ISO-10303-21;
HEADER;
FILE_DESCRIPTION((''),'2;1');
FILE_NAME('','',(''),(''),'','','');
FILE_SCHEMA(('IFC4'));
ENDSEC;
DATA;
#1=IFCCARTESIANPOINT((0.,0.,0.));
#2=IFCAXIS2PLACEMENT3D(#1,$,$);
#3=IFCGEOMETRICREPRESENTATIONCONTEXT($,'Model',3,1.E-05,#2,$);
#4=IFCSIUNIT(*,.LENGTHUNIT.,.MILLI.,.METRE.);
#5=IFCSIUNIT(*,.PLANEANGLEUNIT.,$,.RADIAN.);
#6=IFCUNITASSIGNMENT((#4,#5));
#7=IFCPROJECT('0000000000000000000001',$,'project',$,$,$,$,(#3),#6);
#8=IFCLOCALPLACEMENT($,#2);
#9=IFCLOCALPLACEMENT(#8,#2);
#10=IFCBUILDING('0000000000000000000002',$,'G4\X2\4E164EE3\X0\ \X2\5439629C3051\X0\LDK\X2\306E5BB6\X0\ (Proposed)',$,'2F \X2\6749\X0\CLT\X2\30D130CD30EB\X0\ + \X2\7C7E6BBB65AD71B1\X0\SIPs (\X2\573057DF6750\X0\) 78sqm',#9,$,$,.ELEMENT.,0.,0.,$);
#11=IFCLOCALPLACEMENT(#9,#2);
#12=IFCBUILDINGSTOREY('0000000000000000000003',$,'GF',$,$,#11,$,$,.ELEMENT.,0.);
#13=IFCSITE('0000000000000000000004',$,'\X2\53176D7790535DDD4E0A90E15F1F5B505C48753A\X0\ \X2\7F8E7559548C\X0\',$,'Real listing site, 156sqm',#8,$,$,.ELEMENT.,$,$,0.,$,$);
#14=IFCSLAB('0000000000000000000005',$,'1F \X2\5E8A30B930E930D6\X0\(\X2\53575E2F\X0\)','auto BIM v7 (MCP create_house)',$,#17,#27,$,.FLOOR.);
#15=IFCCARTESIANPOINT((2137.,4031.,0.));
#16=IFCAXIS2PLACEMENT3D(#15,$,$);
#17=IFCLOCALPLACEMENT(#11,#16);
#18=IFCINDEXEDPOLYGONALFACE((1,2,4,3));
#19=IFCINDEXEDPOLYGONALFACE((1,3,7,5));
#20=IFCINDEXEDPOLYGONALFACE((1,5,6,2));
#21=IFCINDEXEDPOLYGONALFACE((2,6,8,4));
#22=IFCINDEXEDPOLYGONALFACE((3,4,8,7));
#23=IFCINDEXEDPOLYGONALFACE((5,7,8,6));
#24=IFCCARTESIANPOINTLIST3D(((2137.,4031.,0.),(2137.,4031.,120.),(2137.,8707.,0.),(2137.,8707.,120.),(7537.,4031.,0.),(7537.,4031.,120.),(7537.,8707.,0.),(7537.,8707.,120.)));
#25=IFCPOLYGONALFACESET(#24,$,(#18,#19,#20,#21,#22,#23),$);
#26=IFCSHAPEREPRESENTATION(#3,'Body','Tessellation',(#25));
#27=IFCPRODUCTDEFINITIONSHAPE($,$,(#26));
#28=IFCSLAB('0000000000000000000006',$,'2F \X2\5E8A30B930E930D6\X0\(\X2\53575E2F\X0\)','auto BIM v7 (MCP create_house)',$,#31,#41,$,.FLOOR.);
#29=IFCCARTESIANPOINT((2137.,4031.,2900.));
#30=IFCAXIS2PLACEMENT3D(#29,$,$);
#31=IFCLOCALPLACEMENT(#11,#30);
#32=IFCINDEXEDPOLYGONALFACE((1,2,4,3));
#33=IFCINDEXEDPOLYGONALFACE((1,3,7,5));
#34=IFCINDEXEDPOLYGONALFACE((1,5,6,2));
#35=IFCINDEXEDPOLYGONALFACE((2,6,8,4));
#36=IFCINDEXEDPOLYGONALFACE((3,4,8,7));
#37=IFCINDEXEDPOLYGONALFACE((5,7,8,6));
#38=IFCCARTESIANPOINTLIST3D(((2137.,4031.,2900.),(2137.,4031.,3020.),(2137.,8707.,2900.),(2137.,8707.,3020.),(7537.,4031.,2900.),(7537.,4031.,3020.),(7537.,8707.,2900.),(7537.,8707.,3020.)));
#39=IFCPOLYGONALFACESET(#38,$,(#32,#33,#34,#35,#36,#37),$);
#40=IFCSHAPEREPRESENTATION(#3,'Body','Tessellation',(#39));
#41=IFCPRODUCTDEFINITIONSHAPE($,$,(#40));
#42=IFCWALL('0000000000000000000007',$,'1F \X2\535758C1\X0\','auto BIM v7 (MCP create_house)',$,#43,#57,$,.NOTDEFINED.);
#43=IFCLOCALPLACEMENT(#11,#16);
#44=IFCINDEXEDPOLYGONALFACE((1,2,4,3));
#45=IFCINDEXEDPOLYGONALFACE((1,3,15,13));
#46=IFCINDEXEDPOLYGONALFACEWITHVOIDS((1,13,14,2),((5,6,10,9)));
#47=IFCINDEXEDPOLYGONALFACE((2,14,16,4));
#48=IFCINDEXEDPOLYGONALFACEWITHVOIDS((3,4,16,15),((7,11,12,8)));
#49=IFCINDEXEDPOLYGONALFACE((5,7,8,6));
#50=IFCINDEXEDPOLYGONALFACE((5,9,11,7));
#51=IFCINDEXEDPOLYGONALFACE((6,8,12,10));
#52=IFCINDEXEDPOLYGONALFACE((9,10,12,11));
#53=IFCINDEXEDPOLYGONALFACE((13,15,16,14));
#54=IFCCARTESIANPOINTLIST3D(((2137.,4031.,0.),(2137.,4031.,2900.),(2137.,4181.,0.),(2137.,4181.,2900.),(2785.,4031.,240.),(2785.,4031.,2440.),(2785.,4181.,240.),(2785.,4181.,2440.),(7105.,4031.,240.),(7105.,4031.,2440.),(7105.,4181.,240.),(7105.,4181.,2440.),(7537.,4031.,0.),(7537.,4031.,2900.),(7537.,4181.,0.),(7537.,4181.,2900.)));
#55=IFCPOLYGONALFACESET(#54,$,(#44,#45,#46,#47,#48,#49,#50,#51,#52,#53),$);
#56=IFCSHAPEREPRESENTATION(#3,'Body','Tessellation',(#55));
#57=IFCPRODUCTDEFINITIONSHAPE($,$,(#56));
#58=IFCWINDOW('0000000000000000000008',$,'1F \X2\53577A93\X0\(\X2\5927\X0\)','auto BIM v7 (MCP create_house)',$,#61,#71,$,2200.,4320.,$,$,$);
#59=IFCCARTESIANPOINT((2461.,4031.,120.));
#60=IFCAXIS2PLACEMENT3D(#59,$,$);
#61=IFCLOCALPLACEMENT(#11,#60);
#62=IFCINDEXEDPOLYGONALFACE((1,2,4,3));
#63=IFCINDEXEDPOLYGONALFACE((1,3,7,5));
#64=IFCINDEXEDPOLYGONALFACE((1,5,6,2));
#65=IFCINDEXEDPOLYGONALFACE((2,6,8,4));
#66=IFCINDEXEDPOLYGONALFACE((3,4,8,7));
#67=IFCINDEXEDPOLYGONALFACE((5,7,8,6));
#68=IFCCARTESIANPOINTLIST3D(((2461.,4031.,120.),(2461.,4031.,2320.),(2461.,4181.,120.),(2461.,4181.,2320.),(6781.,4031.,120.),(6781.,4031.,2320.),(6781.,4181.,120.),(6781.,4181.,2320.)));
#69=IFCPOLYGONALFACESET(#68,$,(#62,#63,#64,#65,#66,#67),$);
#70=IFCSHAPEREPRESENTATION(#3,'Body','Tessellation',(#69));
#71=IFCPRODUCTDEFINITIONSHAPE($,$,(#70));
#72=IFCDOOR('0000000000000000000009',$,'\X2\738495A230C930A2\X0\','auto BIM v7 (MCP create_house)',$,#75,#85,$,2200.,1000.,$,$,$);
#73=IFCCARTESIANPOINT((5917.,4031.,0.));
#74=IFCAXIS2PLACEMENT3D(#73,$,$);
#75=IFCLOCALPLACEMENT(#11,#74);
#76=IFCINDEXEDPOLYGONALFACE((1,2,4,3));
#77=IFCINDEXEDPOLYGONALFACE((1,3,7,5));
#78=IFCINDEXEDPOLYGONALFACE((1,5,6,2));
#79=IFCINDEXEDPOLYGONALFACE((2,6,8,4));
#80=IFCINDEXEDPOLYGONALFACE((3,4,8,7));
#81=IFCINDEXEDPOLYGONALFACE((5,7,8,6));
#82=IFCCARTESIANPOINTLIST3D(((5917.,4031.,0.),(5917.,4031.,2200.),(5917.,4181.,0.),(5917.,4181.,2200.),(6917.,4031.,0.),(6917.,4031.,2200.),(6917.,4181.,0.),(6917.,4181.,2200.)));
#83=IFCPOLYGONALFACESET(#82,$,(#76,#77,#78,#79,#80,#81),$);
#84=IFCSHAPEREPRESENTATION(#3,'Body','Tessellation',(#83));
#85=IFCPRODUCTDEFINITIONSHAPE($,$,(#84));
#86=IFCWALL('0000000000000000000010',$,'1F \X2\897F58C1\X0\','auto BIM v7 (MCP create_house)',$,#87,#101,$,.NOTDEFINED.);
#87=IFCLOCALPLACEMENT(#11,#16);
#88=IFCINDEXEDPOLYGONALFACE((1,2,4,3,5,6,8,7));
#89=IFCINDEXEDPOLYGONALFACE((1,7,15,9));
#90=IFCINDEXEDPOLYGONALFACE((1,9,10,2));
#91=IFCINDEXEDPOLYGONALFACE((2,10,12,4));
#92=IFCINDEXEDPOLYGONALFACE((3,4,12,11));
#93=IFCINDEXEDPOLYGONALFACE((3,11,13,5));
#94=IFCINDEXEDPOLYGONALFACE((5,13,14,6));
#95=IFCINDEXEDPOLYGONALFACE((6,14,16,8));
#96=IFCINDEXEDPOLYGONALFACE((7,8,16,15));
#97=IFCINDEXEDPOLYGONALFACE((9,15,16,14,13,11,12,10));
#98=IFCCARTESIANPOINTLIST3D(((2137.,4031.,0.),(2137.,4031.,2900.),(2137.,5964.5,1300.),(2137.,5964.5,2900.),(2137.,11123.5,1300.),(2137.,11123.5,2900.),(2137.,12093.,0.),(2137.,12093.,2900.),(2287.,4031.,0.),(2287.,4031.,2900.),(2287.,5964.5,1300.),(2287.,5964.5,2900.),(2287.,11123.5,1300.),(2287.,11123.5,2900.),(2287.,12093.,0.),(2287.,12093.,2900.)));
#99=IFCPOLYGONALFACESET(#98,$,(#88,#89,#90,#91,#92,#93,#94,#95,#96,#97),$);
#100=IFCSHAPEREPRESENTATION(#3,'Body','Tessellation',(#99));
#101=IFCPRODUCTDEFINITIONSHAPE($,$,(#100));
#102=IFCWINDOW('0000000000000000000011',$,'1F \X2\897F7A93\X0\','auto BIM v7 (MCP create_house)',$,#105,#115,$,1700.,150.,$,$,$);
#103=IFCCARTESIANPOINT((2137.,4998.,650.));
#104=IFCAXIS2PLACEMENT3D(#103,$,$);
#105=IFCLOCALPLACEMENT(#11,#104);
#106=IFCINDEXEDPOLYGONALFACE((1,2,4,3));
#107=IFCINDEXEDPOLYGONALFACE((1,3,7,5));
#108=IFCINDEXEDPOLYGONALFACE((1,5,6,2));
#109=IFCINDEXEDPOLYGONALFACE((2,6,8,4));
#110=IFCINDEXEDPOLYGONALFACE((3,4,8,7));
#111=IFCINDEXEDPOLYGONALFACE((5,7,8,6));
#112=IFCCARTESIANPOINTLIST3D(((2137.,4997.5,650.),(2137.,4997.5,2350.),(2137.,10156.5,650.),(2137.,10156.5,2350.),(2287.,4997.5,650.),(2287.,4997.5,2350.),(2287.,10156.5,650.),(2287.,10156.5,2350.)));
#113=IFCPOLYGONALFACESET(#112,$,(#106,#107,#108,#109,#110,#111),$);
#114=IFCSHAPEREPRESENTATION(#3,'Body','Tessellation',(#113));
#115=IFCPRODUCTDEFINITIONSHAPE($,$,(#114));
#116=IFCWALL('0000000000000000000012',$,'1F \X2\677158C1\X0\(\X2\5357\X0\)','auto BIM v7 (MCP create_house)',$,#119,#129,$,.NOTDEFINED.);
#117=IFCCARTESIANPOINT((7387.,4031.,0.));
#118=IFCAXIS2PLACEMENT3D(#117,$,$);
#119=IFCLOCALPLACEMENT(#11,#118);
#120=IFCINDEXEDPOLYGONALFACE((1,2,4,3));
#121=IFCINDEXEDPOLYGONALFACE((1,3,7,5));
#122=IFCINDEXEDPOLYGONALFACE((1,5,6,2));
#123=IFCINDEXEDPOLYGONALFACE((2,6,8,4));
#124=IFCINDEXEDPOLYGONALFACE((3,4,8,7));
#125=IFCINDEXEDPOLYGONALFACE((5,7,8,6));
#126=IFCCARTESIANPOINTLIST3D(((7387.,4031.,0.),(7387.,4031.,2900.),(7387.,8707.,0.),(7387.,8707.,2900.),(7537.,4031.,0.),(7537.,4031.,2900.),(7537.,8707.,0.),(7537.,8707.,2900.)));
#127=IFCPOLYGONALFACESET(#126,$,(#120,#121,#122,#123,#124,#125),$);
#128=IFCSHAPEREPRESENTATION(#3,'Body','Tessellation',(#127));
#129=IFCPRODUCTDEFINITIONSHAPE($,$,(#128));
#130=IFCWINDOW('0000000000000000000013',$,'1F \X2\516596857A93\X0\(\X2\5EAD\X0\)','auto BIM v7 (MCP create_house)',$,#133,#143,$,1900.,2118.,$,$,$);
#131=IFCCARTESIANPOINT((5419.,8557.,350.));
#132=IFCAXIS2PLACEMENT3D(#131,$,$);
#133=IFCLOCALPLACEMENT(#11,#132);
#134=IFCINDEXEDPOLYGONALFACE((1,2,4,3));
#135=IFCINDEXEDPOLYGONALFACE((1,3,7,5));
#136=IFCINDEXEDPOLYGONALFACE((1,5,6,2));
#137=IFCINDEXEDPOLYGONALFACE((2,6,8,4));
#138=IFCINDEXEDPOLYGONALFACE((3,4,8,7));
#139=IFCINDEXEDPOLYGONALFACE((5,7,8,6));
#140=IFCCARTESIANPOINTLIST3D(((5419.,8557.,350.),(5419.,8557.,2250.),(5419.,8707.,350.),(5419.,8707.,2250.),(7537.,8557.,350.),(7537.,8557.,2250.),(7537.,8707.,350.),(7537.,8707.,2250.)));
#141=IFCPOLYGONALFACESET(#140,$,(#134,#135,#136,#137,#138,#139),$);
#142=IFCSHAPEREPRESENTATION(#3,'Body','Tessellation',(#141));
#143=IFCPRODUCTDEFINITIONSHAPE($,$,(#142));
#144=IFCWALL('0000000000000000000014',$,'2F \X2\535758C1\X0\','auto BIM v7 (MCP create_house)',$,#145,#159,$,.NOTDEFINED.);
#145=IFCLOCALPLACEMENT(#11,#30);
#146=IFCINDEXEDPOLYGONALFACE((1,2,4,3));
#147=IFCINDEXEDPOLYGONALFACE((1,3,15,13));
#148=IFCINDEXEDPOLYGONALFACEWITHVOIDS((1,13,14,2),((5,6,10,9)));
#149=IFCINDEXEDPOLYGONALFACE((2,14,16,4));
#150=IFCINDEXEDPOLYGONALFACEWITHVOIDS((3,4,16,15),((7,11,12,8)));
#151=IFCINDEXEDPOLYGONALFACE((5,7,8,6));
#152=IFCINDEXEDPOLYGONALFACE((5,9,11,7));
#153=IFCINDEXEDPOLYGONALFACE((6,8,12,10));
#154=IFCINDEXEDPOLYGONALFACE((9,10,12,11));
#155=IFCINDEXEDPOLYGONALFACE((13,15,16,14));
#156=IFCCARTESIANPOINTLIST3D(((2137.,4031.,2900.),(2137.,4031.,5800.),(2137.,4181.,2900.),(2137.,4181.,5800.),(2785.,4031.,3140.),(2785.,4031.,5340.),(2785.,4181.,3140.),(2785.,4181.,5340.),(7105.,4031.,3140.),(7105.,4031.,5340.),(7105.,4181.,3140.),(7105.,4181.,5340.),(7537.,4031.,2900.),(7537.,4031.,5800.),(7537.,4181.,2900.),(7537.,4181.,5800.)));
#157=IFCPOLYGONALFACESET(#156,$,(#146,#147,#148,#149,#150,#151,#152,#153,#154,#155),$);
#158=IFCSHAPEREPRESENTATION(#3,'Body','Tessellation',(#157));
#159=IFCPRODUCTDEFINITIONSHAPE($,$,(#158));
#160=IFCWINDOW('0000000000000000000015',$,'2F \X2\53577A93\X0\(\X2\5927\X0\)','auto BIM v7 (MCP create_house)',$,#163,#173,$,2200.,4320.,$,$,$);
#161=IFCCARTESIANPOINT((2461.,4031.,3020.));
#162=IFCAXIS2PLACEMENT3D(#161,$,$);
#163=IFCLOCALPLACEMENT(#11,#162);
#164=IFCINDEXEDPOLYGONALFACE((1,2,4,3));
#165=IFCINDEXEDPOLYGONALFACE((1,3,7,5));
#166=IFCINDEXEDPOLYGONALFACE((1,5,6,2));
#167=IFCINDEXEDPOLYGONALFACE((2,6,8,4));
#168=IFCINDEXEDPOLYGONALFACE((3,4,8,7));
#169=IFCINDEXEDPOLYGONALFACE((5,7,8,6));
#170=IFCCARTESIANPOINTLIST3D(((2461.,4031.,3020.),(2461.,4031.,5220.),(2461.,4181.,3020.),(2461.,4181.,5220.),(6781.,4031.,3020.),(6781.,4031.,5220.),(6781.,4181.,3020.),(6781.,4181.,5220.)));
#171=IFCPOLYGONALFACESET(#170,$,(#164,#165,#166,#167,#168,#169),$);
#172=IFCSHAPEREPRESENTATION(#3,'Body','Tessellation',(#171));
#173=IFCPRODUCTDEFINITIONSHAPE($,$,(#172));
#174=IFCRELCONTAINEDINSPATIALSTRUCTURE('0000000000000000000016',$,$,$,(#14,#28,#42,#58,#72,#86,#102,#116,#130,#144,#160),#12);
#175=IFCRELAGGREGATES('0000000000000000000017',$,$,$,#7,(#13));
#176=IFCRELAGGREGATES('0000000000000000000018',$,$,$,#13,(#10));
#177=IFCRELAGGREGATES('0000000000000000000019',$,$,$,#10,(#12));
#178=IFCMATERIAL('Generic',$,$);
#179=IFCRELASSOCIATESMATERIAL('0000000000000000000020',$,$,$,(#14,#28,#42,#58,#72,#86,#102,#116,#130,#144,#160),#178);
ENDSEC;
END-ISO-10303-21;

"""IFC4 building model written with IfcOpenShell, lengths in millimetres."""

from ifc_helpers import new_model, si_unit, frame, frame_2d, origin, place, context, project, spatial, rectangle, extrude, material, element, fill, save


model = new_model("IFC4")

# Units and contexts
model_context = context("Model", 3, precision=1e-05, world=origin())
ifc_project = project(units=[si_unit("LENGTHUNIT", "METRE", prefix="MILLI"), si_unit("PLANEANGLEUNIT", "RADIAN")], contexts=[model_context])

# Site, building, storey
site_placement = place(None, origin())
site = spatial("IfcSite", under=ifc_project, at=site_placement, Name="北海道川上郡弟子屈町 美留和", ObjectType="Real listing site, 156sqm", CompositionType="ELEMENT", RefElevation=0.0)
building_placement = place(site_placement, origin())
building = spatial("IfcBuilding", under=site, at=building_placement, Name="G4世代 吹抜けLDKの家 (Proposed)", ObjectType="2F 杉CLTパネル + 籾殻断熱SIPs (地域材) 78sqm", CompositionType="ELEMENT", ElevationOfRefHeight=0.0, ElevationOfTerrain=0.0)
storey_placement = place(building_placement, origin())
storey = spatial("IfcBuildingStorey", under=building, at=storey_placement, Name="GF", CompositionType="ELEMENT", Elevation=0.0)

# Slabs
ifc_material = material(Name="Generic")
slab_1_placement = place(storey_placement, frame((2137.0, 4031.0, 0.0)))
element("IfcSlab", 1, at=slab_1_placement, inside=storey, material=ifc_material, Name="1F 床スラブ(南帯)", Description="auto BIM v7 (MCP create_house)", PredefinedType="FLOOR", context=model_context, shape_type="SweptSolid", body=[
    extrude(rectangle(XDim=5400.0, YDim=4676.0, at=frame_2d((2700.0, 2338.0))), frame((2137.0, 4031.0, 0.0)), (0.0, 0.0, 1.0), 120.0),
])
slab_2_placement = place(storey_placement, frame((2137.0, 4031.0, 2900.0)))
element("IfcSlab", 2, at=slab_2_placement, inside=storey, material=ifc_material, Name="2F 床スラブ(南帯)", Description="auto BIM v7 (MCP create_house)", PredefinedType="FLOOR", context=model_context, shape_type="SweptSolid", body=[
    extrude(rectangle(XDim=5400.0, YDim=4676.0, at=frame_2d((2700.0, 2338.0))), frame((2137.0, 4031.0, 2900.0)), (0.0, 0.0, 1.0), 120.0),
])

# Wall, openings, window, door
wall_1_placement = place(storey_placement, frame((2137.0, 4031.0, 0.0)))
wall_1 = element("IfcWall", 3, at=wall_1_placement, inside=storey, material=ifc_material, Name="1F 南壁", Description="auto BIM v7 (MCP create_house)", PredefinedType="NOTDEFINED", context=model_context, shape_type="SweptSolid", body=[
    extrude(rectangle(XDim=5400.0, YDim=150.0, at=frame_2d((2700.0, 75.0))), frame((2137.0, 4031.0, 0.0)), (0.0, 0.0, 1.0), 2900.0),
])
opening_1_placement = place(storey_placement, frame((2461.0, 4031.0, 120.0)))
opening_1 = element("IfcOpeningElement", 4, at=opening_1_placement, cuts=wall_1, PredefinedType="NOTDEFINED", context=model_context, shape_type="SweptSolid", body=[
    extrude(rectangle(XDim=4320.0, YDim=150.0, at=frame_2d((2160.0, 75.0))), frame((2461.0, 4031.0, 120.0)), (0.0, 0.0, 1.0), 2200.0),
])
opening_2_placement = place(storey_placement, frame((5917.0, 4031.0, 0.0)))
opening_2 = element("IfcOpeningElement", 5, at=opening_2_placement, cuts=wall_1, PredefinedType="NOTDEFINED", context=model_context, shape_type="SweptSolid", body=[
    extrude(rectangle(XDim=1000.0, YDim=150.0, at=frame_2d((500.0, 75.0))), frame((5917.0, 4031.0, 0.0)), (0.0, 0.0, 1.0), 2200.0),
])
window_1_placement = place(storey_placement, frame((2461.0, 4031.0, 120.0)))
window_1 = element("IfcWindow", 6, at=window_1_placement, inside=storey, material=ifc_material, Name="1F 南窓(大)", Description="auto BIM v7 (MCP create_house)", OverallHeight=2200.0, OverallWidth=4320.0, context=model_context, shape_type="SweptSolid", body=[
    extrude(rectangle(XDim=4320.0, YDim=150.0, at=frame_2d((2160.0, 75.0))), frame((2461.0, 4031.0, 120.0)), (0.0, 0.0, 1.0), 2200.0),
])
fill(opening_1, window_1)
door_placement = place(storey_placement, frame((5917.0, 4031.0, 0.0)))
door = element("IfcDoor", 7, at=door_placement, inside=storey, material=ifc_material, Name="玄関ドア", Description="auto BIM v7 (MCP create_house)", OverallHeight=2200.0, OverallWidth=1000.0, context=model_context, shape_type="SweptSolid", body=[
    extrude(rectangle(XDim=1000.0, YDim=150.0, at=frame_2d((500.0, 75.0))), frame((5917.0, 4031.0, 0.0)), (0.0, 0.0, 1.0), 2200.0),
])
fill(opening_2, door)

# Walls, openings, windows
wall_2_placement = place(storey_placement, frame((2137.0, 4031.0, 0.0)))
wall_2 = element("IfcWall", 8, at=wall_2_placement, inside=storey, material=ifc_material, Name="1F 西壁", Description="auto BIM v7 (MCP create_house)", PredefinedType="NOTDEFINED", context=model_context, shape_type="SweptSolid", body=[
    extrude(rectangle(XDim=150.0, YDim=8062.0, at=frame_2d((75.0, 4031.0))), frame((2137.0, 4031.0, 0.0)), (0.0, 0.0, 1.0), 2900.0),
])
opening_3_placement = place(storey_placement, frame((2137.0, 4998.0, 650.0)))
opening_3 = element("IfcOpeningElement", 9, at=opening_3_placement, cuts=wall_2, PredefinedType="NOTDEFINED", context=model_context, shape_type="SweptSolid", body=[
    extrude(rectangle(XDim=150.0, YDim=5159.0, at=frame_2d((75.0, 2579.0))), frame((2137.0, 4998.0, 650.0)), (0.0, 0.0, 1.0), 1700.0),
])
window_2_placement = place(storey_placement, frame((2137.0, 4998.0, 650.0)))
window_2 = element("IfcWindow", 10, at=window_2_placement, inside=storey, material=ifc_material, Name="1F 西窓", Description="auto BIM v7 (MCP create_house)", OverallHeight=1700.0, OverallWidth=150.0, context=model_context, shape_type="SweptSolid", body=[
    extrude(rectangle(XDim=150.0, YDim=5159.0, at=frame_2d((75.0, 2579.0))), frame((2137.0, 4998.0, 650.0)), (0.0, 0.0, 1.0), 1700.0),
])
fill(opening_3, window_2)
wall_3_placement = place(storey_placement, frame((7387.0, 4031.0, 0.0)))
wall_3 = element("IfcWall", 11, at=wall_3_placement, inside=storey, material=ifc_material, Name="1F 東壁(南)", Description="auto BIM v7 (MCP create_house)", PredefinedType="NOTDEFINED", context=model_context, shape_type="SweptSolid", body=[
    extrude(rectangle(XDim=150.0, YDim=4676.0, at=frame_2d((75.0, 2338.0))), frame((7387.0, 4031.0, 0.0)), (0.0, 0.0, 1.0), 2900.0),
])
opening_4_placement = place(storey_placement, frame((5419.0, 8557.0, 350.0)))
opening_4 = element("IfcOpeningElement", 12, at=opening_4_placement, cuts=wall_3, PredefinedType="NOTDEFINED", context=model_context, shape_type="SweptSolid", body=[
    extrude(rectangle(XDim=2118.0, YDim=150.0, at=frame_2d((1059.0, 75.0))), frame((5419.0, 8557.0, 350.0)), (0.0, 0.0, 1.0), 1900.0),
])
window_3_placement = place(storey_placement, frame((5419.0, 8557.0, 350.0)))
window_3 = element("IfcWindow", 13, at=window_3_placement, inside=storey, material=ifc_material, Name="1F 入隅窓(庭)", Description="auto BIM v7 (MCP create_house)", OverallHeight=1900.0, OverallWidth=2118.0, context=model_context, shape_type="SweptSolid", body=[
    extrude(rectangle(XDim=2118.0, YDim=150.0, at=frame_2d((1059.0, 75.0))), frame((5419.0, 8557.0, 350.0)), (0.0, 0.0, 1.0), 1900.0),
])
fill(opening_4, window_3)

# Wall, opening, window
wall_4_placement = place(storey_placement, frame((2137.0, 4031.0, 2900.0)))
wall_4 = element("IfcWall", 14, at=wall_4_placement, inside=storey, material=ifc_material, Name="2F 南壁", Description="auto BIM v7 (MCP create_house)", PredefinedType="NOTDEFINED", context=model_context, shape_type="SweptSolid", body=[
    extrude(rectangle(XDim=5400.0, YDim=150.0, at=frame_2d((2700.0, 75.0))), frame((2137.0, 4031.0, 2900.0)), (0.0, 0.0, 1.0), 2900.0),
])
opening_5_placement = place(storey_placement, frame((2461.0, 4031.0, 3020.0)))
opening_5 = element("IfcOpeningElement", 15, at=opening_5_placement, cuts=wall_4, PredefinedType="NOTDEFINED", context=model_context, shape_type="SweptSolid", body=[
    extrude(rectangle(XDim=4320.0, YDim=150.0, at=frame_2d((2160.0, 75.0))), frame((2461.0, 4031.0, 3020.0)), (0.0, 0.0, 1.0), 2200.0),
])
window_4_placement = place(storey_placement, frame((2461.0, 4031.0, 3020.0)))
window_4 = element("IfcWindow", 16, at=window_4_placement, inside=storey, material=ifc_material, Name="2F 南窓(大)", Description="auto BIM v7 (MCP create_house)", OverallHeight=2200.0, OverallWidth=4320.0, context=model_context, shape_type="SweptSolid", body=[
    extrude(rectangle(XDim=4320.0, YDim=150.0, at=frame_2d((2160.0, 75.0))), frame((2461.0, 4031.0, 3020.0)), (0.0, 0.0, 1.0), 2200.0),
])
fill(opening_5, window_4)

save(model, "model.ifc")
